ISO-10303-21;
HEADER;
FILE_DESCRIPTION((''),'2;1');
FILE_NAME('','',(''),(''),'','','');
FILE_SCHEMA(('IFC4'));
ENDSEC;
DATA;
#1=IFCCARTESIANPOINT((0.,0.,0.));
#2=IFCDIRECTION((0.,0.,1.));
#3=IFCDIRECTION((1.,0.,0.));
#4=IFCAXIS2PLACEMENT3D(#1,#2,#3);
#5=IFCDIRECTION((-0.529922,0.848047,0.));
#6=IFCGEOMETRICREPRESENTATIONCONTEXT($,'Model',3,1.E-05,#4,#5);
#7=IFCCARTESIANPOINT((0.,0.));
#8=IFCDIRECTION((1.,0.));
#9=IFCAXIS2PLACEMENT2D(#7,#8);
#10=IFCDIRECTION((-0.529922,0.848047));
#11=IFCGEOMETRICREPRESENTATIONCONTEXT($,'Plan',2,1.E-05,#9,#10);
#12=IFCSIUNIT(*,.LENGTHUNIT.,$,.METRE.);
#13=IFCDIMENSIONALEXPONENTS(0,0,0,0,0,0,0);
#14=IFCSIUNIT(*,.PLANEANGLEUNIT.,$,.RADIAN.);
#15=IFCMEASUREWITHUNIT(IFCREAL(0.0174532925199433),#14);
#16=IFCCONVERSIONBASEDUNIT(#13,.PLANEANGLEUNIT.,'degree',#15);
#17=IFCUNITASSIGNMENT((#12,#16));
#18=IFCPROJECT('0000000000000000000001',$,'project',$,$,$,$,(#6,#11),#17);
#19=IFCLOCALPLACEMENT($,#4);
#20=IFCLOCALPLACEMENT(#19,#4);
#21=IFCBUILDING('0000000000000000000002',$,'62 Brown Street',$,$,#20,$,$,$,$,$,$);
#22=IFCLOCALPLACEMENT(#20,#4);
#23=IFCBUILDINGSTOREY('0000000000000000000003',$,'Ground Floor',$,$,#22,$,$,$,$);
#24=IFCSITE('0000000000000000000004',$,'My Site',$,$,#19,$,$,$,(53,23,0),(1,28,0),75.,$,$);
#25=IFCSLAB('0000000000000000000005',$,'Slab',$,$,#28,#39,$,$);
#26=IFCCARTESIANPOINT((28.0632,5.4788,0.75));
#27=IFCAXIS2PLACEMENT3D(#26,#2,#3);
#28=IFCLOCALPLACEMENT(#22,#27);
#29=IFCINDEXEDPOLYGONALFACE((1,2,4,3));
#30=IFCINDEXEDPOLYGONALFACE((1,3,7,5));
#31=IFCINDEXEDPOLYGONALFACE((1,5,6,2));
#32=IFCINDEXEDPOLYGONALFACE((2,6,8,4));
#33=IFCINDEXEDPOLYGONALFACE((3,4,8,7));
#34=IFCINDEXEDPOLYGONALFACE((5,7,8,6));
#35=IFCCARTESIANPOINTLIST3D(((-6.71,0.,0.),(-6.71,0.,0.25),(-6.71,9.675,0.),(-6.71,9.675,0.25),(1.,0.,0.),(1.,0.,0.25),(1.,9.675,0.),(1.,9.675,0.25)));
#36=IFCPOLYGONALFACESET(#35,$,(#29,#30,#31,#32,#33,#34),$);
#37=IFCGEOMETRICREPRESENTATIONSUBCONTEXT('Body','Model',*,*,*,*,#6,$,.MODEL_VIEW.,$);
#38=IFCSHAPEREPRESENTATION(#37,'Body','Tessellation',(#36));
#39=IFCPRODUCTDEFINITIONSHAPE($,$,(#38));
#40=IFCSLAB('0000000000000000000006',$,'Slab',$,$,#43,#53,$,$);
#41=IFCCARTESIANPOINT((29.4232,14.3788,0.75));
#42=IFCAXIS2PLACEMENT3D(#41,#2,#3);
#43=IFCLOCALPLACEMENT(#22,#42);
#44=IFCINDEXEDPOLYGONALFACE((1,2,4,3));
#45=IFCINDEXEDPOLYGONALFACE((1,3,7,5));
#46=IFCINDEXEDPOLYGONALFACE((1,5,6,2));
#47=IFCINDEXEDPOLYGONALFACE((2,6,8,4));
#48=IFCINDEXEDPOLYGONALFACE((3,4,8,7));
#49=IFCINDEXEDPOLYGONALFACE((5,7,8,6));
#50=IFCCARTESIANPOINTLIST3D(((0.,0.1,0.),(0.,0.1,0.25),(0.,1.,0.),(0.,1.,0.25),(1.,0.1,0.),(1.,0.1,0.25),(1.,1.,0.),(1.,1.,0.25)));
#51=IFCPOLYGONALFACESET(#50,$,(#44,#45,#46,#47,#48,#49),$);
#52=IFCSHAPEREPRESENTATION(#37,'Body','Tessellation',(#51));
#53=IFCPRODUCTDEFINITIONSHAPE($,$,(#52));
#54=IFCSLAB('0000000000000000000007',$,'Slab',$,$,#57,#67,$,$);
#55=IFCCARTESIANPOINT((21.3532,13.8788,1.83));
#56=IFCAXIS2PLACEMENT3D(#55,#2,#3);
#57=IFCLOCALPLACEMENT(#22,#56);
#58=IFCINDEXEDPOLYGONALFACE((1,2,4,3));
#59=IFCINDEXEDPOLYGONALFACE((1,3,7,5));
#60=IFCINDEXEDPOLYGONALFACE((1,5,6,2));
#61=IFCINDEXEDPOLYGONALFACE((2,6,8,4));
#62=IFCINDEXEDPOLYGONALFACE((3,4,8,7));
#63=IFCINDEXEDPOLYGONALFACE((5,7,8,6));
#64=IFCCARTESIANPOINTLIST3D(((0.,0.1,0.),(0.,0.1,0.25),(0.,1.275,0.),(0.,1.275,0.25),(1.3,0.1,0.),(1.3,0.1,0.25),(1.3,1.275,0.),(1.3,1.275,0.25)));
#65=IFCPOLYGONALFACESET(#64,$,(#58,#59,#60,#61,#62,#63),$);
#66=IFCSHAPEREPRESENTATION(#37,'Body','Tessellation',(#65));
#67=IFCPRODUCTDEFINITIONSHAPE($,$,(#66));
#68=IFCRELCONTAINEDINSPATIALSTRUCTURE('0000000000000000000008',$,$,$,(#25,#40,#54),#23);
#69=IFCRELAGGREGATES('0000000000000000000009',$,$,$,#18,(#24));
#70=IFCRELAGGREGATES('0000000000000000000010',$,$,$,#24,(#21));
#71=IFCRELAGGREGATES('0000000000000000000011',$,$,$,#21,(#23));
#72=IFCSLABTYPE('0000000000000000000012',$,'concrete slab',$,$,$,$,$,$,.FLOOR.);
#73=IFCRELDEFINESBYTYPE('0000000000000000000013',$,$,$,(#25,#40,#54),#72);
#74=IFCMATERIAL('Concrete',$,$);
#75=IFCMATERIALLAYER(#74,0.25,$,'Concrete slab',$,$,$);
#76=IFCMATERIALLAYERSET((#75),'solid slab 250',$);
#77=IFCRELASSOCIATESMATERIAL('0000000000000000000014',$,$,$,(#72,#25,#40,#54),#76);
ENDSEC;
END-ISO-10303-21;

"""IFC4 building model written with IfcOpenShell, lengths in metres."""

from ifc_helpers import new_model, entity, si_unit, converted_unit, direction, frame, origin_with_axes, origin_2d_with_axis, place, context, subcontext, project, spatial, line, indexed_curve, outline, extrude, material, layer, layer_set, layer_usage, type_object, element, save


model = new_model("IFC4")

# Units and contexts
model_context = context("Model", 3, precision=1e-05, world=origin_with_axes(), true_north=direction((-0.529922, 0.848047, 0.0)))
plan_context = context("Plan", 2, precision=1e-05, world=origin_2d_with_axis(), true_north=direction((-0.529922, 0.848047)))
body_context_1 = subcontext(model_context, "Body", "Model", "MODEL_VIEW")
ifc_project = project(units=[si_unit("LENGTHUNIT", "METRE"), converted_unit("PLANEANGLEUNIT", "degree", entity("IfcReal", 0.0174532925199433), si_unit("PLANEANGLEUNIT", "RADIAN"), dimensions=[0, 0, 0, 0, 0, 0, 0])], contexts=[model_context, plan_context])

# Site, building, storey
site_placement = place(None, origin_with_axes())
site = spatial("IfcSite", under=ifc_project, at=site_placement, Name="My Site", RefLatitude=(53, 23, 0), RefLongitude=(1, 28, 0), RefElevation=75.0)
building_placement = place(site_placement, origin_with_axes())
building = spatial("IfcBuilding", under=site, at=building_placement, Name="62 Brown Street")
storey_placement = place(building_placement, origin_with_axes())
storey = spatial("IfcBuildingStorey", under=building, at=storey_placement, Name="Ground Floor")

# Shared definitions
ifc_material_1 = material(Name="Concrete")

# Slabs
ifc_layer_1 = layer(ifc_material_1, 0.25, Name="Concrete slab")
ifc_layer_set_1 = layer_set([ifc_layer_1], Name="solid slab 250")
slab_type = type_object("IfcSlabType", Name="concrete slab", PredefinedType="FLOOR", material=ifc_layer_set_1)
ifc_layer_usage_1 = layer_usage(ifc_layer_set_1, "AXIS3", "POSITIVE", 0.0)
slab_1_placement = place(storey_placement, frame((28.0632, 5.4788, 0.75), z_axis=(0.0, 0.0, 1.0), x_axis=(1.0, 0.0, 0.0)))
element("IfcSlab", 1, at=slab_1_placement, inside=storey, type_object=slab_type, material=ifc_layer_usage_1, Name="Slab", context=body_context_1, shape_type="SweptSolid", body=[
    extrude(outline(indexed_curve([(-6.71, 0.0), (-6.71, 9.675), (1.0, 9.675), (1.0, 0.0), (-6.71, 0.0)])), None, (0.0, 0.0, 1.0), 0.25),
])
ifc_layer_usage_2 = layer_usage(ifc_layer_set_1, "AXIS3", "POSITIVE", 0.0)
slab_2_placement = place(storey_placement, frame((29.4232, 14.3788, 0.75), z_axis=(0.0, 0.0, 1.0), x_axis=(1.0, 0.0, 0.0)))
element("IfcSlab", 2, at=slab_2_placement, inside=storey, type_object=slab_type, material=ifc_layer_usage_2, Name="Slab", context=body_context_1, shape_type="SweptSolid", body=[
    extrude(outline(indexed_curve([(1.0, 1.0), (1.0, 0.1), (0.0, 0.1), (0.0, 1.0)], segments=[line(3, 2), line(2, 1), line(1, 4), line(4, 3)], self_intersect=False)), None, (0.0, 0.0, 1.0), 0.25),
])
ifc_layer_usage_3 = layer_usage(ifc_layer_set_1, "AXIS3", "POSITIVE", 0.0)
slab_3_placement = place(storey_placement, frame((21.3532, 13.8788, 1.83), z_axis=(0.0, 0.0, 1.0), x_axis=(1.0, 0.0, 0.0)))
element("IfcSlab", 3, at=slab_3_placement, inside=storey, type_object=slab_type, material=ifc_layer_usage_3, Name="Slab", context=body_context_1, shape_type="SweptSolid", body=[
    extrude(outline(indexed_curve([(0.0, 0.1), (1.3, 0.1), (1.3, 1.275), (0.0, 1.275), (0.0, 0.1)])), None, (0.0, 0.0, 1.0), 0.25),
])

save(model, "model.ifc")
